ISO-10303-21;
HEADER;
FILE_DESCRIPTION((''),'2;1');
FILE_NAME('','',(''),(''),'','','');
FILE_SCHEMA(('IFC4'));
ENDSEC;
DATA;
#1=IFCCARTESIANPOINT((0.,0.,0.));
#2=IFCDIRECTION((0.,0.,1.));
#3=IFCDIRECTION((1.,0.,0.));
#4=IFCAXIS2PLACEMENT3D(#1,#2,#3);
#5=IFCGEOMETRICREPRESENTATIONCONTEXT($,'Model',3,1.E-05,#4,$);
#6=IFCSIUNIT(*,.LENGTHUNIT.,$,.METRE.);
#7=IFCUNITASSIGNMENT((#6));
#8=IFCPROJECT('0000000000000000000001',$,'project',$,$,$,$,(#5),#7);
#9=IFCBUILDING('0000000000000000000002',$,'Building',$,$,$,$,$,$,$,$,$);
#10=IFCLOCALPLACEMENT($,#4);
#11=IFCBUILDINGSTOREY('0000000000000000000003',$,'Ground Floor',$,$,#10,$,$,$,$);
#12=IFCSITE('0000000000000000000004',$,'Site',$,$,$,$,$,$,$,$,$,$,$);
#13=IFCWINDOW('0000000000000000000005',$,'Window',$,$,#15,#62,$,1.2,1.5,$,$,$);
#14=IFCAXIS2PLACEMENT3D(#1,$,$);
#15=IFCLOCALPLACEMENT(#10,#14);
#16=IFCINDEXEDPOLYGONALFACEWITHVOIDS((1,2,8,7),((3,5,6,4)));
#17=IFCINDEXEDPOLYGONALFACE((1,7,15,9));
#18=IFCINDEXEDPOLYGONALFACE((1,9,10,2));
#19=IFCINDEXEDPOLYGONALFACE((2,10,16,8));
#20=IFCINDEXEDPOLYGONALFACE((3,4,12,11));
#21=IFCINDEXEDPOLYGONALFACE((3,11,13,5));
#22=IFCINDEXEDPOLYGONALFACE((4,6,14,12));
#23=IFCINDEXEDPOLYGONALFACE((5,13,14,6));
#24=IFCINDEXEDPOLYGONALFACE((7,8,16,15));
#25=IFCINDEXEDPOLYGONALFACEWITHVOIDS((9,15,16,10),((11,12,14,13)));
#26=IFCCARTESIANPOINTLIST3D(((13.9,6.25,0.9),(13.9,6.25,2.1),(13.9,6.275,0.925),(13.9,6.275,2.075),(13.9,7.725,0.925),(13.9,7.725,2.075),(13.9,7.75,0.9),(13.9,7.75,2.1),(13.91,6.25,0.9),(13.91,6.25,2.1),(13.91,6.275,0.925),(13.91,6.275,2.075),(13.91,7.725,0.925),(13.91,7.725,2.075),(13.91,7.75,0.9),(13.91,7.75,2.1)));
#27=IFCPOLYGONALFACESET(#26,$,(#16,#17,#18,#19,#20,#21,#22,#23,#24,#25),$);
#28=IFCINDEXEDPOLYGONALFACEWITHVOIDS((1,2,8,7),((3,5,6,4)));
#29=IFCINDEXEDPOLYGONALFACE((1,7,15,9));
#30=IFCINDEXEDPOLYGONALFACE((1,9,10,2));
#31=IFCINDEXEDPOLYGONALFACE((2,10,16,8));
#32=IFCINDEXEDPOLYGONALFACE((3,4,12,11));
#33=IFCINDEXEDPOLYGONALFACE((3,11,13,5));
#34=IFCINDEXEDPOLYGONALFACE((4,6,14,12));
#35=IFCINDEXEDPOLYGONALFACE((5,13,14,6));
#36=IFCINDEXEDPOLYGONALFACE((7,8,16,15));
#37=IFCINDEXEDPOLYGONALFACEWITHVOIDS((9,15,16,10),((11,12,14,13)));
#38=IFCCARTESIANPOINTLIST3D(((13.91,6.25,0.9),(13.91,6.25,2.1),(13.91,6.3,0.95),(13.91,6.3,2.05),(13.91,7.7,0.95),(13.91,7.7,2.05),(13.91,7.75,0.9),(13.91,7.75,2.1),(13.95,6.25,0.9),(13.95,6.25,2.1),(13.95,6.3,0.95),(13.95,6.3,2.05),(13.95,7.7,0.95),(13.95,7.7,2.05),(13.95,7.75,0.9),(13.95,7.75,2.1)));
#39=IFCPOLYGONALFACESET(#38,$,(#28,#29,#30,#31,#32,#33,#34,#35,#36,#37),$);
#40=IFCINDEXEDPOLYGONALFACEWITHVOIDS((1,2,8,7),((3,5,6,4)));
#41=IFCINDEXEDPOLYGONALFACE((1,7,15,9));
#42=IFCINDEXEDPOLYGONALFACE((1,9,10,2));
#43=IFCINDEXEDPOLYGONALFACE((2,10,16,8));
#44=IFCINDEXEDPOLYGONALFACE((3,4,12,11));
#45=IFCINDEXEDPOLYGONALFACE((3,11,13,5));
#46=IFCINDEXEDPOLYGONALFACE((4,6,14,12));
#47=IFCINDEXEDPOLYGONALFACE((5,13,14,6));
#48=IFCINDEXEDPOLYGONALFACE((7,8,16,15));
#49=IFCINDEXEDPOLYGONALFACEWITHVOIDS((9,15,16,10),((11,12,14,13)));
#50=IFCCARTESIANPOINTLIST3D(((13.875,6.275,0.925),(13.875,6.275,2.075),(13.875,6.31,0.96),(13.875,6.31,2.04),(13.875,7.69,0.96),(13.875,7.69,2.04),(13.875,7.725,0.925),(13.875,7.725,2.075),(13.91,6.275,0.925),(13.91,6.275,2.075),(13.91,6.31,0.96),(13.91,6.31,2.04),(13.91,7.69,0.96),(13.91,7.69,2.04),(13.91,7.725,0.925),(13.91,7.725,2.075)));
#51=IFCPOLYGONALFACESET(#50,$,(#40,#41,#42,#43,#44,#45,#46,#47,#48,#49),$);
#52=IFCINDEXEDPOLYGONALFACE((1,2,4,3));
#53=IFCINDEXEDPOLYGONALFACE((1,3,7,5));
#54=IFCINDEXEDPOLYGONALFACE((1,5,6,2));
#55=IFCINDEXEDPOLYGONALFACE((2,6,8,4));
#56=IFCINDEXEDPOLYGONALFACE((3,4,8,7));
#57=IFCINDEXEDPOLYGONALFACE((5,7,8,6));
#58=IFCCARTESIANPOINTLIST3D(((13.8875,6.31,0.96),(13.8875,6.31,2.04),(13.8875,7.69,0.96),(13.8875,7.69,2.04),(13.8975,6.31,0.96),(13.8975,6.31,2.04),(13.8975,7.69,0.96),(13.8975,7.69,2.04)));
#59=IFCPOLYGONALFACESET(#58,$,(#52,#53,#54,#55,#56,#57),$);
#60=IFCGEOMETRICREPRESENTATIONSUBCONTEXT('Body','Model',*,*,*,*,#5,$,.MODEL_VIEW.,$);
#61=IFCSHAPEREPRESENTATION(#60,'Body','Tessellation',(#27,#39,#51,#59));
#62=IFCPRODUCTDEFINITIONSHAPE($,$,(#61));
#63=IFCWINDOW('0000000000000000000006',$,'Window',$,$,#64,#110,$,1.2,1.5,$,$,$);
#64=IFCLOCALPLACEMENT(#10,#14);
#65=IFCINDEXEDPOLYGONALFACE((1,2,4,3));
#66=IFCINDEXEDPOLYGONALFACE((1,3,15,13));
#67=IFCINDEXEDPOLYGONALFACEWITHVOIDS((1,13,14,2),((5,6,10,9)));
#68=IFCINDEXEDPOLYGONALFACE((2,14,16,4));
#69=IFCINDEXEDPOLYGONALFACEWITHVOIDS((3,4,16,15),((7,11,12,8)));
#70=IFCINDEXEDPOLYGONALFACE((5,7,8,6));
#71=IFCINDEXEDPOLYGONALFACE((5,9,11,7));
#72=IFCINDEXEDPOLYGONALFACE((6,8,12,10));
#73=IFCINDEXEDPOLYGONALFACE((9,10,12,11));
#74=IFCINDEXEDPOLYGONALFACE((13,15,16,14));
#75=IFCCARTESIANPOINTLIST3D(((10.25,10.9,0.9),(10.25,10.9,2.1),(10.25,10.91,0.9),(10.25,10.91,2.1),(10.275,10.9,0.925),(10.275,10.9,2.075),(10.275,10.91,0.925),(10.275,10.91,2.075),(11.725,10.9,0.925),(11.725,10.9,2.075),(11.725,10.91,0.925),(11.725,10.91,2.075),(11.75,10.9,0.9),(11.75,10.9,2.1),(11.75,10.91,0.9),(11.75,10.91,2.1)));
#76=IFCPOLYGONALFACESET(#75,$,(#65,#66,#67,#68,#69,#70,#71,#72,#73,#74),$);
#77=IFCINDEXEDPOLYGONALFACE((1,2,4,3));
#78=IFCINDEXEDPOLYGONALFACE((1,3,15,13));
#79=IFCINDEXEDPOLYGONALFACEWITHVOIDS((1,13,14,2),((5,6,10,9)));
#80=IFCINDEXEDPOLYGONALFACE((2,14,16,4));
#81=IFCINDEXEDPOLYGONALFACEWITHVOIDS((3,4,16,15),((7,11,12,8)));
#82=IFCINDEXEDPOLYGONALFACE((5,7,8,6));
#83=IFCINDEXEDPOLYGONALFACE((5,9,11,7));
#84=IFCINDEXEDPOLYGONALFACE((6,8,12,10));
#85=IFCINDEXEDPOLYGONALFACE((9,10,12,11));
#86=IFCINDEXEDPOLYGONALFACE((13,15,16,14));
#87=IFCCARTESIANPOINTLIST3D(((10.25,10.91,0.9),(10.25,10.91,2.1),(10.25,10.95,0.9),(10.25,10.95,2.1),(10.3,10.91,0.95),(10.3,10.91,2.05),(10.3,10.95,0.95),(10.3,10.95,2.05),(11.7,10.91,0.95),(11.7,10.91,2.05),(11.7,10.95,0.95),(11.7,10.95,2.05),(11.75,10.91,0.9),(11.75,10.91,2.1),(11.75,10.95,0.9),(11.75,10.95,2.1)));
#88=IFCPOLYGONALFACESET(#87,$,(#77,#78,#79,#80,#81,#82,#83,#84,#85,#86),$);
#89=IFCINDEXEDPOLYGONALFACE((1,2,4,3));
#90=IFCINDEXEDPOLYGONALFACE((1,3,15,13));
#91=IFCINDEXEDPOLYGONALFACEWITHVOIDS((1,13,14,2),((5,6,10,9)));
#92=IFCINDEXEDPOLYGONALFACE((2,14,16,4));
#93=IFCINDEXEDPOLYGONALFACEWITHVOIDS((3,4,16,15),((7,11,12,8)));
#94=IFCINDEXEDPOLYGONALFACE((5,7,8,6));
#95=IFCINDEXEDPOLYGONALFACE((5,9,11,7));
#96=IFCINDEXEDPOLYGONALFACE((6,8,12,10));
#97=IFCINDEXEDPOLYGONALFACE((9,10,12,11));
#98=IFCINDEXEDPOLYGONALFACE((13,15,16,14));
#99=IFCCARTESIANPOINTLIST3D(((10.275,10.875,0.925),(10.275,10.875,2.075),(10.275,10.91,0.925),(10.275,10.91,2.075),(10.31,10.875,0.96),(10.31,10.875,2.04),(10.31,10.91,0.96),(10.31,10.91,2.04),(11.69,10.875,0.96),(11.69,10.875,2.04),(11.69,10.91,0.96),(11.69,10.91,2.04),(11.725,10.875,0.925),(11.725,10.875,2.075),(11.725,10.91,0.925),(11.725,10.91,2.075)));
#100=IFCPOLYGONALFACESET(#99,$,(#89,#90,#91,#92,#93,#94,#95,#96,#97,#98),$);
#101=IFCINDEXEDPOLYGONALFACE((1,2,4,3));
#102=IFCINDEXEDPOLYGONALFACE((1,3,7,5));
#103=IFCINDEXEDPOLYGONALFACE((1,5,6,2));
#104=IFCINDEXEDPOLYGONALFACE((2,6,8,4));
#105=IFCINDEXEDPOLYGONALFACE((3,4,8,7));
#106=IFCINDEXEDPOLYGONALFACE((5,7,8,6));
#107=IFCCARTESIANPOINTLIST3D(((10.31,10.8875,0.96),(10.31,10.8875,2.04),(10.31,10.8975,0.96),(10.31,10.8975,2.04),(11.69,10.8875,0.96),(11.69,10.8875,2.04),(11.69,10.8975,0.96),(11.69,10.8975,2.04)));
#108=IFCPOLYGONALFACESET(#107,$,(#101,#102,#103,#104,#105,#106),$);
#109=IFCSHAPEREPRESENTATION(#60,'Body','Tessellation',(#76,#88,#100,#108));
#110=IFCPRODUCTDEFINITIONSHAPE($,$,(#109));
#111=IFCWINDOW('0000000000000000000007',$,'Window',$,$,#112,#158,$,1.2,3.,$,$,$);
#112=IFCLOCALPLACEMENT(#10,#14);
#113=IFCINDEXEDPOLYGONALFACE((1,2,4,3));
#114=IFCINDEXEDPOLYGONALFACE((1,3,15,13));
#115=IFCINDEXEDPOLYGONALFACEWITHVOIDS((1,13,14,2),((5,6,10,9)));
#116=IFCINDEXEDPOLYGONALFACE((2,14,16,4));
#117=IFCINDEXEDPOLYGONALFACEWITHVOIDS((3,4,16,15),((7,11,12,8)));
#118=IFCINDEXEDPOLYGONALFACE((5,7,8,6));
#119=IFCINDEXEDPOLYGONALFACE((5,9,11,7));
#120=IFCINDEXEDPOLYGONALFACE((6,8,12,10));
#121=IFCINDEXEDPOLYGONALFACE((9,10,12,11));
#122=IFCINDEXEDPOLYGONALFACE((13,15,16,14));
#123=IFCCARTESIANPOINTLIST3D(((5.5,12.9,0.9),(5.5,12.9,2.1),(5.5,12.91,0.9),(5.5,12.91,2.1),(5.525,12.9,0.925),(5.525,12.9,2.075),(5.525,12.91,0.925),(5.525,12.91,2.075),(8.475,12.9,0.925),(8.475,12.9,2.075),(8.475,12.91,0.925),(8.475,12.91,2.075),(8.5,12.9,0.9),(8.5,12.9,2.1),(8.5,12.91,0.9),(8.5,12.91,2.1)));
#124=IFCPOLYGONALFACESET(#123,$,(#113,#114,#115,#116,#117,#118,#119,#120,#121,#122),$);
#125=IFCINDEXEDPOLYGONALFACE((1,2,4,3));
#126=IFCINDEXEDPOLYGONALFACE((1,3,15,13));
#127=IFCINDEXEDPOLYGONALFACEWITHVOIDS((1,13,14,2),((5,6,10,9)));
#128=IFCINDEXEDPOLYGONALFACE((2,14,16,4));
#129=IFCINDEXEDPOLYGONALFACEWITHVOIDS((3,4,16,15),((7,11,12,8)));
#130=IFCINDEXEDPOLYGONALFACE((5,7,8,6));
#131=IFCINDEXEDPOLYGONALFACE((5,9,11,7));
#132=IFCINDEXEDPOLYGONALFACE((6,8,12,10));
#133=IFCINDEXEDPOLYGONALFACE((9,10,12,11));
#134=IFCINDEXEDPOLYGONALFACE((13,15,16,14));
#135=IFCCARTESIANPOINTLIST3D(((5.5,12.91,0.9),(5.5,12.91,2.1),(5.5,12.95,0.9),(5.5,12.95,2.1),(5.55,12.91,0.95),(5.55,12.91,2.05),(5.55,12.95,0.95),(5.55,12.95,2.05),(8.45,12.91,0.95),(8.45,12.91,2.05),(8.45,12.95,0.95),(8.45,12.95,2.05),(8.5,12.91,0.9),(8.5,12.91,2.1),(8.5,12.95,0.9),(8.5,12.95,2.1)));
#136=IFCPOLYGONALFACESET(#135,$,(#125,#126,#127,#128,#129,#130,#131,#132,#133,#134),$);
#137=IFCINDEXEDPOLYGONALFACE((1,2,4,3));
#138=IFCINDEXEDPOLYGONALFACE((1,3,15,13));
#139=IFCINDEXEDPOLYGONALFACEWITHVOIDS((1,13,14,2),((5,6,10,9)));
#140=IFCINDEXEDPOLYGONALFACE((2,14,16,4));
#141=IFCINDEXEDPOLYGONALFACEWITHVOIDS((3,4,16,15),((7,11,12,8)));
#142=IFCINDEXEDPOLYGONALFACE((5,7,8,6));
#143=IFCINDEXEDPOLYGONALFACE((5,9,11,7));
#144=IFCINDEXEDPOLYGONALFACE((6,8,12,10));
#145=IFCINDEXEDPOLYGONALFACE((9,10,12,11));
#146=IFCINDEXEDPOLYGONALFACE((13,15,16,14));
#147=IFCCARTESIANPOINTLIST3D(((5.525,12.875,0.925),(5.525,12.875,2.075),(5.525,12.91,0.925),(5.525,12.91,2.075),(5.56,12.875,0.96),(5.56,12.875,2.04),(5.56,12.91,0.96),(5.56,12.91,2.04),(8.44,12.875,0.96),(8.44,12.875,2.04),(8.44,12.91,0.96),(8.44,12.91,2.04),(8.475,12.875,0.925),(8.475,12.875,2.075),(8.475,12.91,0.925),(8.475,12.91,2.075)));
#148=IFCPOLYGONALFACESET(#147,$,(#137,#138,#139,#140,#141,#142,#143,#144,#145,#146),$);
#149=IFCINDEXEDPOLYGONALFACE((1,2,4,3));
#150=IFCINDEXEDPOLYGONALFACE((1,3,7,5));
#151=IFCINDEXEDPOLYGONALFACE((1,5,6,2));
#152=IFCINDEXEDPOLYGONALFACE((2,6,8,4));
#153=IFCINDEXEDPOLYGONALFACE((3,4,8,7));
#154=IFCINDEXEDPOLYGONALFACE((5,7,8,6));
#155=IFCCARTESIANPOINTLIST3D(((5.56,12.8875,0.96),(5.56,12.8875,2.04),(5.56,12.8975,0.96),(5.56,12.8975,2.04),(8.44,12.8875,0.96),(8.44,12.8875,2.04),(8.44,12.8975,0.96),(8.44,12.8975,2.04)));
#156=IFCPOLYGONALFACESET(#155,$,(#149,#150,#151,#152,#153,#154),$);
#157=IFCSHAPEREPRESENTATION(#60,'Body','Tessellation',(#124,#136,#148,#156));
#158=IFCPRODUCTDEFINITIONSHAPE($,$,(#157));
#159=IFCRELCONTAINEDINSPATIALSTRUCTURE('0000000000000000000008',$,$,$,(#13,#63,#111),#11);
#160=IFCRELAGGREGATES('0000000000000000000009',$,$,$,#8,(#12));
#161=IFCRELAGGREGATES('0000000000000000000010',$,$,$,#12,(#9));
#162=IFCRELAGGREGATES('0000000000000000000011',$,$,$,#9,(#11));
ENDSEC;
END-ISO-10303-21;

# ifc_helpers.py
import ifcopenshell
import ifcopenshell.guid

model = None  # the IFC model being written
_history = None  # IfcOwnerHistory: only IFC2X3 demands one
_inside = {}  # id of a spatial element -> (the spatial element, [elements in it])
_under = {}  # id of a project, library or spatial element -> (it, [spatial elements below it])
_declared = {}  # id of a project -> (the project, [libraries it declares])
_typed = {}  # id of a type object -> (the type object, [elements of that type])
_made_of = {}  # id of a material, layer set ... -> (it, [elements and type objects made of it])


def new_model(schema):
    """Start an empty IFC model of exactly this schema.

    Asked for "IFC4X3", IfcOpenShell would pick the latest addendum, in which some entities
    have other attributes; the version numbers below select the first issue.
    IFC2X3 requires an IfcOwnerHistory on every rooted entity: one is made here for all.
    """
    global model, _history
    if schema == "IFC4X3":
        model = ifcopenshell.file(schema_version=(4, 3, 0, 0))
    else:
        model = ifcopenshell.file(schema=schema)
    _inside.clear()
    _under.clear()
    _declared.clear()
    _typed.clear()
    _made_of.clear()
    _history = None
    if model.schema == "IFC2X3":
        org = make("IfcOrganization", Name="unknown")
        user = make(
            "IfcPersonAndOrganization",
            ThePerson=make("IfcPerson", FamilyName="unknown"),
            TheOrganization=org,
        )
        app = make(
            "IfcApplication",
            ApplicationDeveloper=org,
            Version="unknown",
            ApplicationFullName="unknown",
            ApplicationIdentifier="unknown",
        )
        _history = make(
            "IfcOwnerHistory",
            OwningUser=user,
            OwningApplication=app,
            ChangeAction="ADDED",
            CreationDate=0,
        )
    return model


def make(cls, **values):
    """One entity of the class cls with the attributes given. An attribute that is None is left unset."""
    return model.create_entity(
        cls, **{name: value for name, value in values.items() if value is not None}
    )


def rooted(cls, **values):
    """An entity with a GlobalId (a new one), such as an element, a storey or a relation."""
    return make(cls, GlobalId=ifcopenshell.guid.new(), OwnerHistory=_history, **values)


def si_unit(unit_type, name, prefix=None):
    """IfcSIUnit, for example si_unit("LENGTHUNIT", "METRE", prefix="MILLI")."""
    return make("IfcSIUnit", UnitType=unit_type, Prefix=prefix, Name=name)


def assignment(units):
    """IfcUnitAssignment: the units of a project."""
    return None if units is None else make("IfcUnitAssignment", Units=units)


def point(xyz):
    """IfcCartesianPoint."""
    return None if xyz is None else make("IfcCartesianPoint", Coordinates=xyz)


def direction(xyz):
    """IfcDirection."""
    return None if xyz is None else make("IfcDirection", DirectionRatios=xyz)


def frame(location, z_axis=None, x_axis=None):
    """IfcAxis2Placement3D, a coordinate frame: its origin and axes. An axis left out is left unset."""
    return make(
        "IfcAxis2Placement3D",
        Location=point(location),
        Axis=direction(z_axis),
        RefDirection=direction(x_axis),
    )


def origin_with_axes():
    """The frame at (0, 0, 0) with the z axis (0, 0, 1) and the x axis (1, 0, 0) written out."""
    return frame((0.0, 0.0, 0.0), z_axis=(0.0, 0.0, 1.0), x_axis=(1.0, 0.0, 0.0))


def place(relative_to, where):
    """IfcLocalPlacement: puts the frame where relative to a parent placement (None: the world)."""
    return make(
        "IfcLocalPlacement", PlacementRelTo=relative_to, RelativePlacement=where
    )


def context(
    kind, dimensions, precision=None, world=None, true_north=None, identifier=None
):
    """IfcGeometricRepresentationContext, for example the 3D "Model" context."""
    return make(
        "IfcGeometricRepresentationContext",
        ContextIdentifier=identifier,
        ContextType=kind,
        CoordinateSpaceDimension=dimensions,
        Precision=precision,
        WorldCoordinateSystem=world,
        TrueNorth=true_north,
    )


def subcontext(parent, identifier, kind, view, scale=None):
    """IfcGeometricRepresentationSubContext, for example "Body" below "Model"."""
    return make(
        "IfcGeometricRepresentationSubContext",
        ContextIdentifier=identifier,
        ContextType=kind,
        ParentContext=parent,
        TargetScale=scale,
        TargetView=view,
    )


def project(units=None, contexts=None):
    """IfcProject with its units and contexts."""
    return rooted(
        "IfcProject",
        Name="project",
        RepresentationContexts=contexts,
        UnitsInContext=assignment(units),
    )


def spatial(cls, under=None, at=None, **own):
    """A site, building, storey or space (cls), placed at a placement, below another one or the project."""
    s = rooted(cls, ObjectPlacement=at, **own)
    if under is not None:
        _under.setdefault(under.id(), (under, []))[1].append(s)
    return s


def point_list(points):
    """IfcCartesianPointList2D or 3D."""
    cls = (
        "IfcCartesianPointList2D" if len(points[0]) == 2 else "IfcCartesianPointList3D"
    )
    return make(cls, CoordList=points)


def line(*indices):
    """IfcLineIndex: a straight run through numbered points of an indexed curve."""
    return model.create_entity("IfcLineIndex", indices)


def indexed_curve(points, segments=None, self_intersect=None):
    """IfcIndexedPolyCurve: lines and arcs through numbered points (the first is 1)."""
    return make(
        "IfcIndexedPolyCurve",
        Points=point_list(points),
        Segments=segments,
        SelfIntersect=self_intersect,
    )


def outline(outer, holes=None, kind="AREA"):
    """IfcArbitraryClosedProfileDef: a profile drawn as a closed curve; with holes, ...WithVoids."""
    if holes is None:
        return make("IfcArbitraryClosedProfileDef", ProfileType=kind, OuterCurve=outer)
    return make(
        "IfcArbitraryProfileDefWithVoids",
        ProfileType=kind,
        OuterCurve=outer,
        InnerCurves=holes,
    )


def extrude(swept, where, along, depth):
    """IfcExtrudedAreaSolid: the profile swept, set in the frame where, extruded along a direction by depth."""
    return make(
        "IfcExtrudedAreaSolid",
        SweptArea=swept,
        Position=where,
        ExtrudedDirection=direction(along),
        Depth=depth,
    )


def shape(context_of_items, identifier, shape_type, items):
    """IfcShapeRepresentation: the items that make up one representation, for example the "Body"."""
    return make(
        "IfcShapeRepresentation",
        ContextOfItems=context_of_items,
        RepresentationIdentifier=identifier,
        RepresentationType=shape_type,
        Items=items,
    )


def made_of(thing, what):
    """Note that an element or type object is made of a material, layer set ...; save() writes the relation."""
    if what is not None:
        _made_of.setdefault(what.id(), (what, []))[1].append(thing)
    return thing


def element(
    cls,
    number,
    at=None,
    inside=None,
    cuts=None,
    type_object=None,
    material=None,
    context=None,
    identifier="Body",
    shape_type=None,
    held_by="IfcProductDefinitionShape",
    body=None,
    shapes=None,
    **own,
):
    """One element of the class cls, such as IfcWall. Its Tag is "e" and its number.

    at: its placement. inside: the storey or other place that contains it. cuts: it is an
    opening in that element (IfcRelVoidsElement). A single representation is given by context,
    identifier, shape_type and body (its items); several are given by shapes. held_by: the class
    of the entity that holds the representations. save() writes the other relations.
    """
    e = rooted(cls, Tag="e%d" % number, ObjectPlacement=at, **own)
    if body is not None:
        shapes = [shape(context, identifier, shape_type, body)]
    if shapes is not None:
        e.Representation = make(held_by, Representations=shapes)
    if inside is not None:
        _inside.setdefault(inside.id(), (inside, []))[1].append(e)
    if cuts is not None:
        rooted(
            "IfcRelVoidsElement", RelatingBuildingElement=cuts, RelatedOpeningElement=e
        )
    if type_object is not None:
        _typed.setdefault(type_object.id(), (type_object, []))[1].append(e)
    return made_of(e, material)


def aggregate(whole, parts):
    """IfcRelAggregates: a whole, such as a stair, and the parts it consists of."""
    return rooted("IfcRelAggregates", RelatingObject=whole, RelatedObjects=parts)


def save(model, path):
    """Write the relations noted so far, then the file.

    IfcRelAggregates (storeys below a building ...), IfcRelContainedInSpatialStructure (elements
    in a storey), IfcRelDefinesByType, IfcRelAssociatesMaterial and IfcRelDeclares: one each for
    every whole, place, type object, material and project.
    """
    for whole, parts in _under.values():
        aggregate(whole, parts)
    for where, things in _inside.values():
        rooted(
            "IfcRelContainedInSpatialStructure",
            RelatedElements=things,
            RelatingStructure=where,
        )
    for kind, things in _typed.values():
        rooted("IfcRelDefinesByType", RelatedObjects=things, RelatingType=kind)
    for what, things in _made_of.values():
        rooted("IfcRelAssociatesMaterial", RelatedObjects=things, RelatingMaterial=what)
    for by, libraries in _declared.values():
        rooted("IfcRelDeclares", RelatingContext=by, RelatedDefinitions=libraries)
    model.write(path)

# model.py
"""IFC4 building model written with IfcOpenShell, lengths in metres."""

from ifc_helpers import new_model, si_unit, frame, origin_with_axes, place, context, subcontext, project, spatial, line, indexed_curve, outline, extrude, element, save


model = new_model("IFC4")

# Units and contexts
model_context = context("Model", 3, precision=1e-05, world=origin_with_axes())
body_context = subcontext(model_context, "Body", "Model", "MODEL_VIEW")
ifc_project = project(units=[si_unit("LENGTHUNIT", "METRE")], contexts=[model_context])

# Site, building, storey
site = spatial("IfcSite", under=ifc_project, Name="Site")
building = spatial("IfcBuilding", under=site, Name="Building")
storey_placement = place(None, origin_with_axes())
storey = spatial("IfcBuildingStorey", under=building, at=storey_placement, Name="Ground Floor")

# Windows
for number, where, z_axis, x_axis, name in (
    (1, (14.0, 6.25, 0.9), (0.0, 0.0, 1.0), (0.0, 1.0, 0.0), "Window"),
    (2, (11.75, 11.0, 0.9), (0.0, 0.0, 1.0), (-1.0, 0.0, 0.0), "Window"),
):
    element("IfcWindow", number, at=place(storey_placement, frame(where, z_axis=z_axis, x_axis=x_axis)), inside=storey, Name=name, OverallHeight=1.2, OverallWidth=1.5, context=body_context, shape_type="SweptSolid", body=[
        extrude(outline(indexed_curve([(0.0, 0.0), (1.5, 0.0), (1.5, 1.2), (0.0, 1.2)], segments=[line(1, 2, 3, 4, 1)]), holes=[indexed_curve([(0.025, 0.025), (1.475, 0.025), (1.475, 1.175), (0.025, 1.175)], segments=[line(1, 2, 3, 4, 1)])]), frame((0.0, 0.09, 0.0), z_axis=(0.0, -1.0, 0.0), x_axis=(1.0, 0.0, 0.0)), (0.0, 0.0, -1.0), 0.01),
        extrude(outline(indexed_curve([(0.0, 0.0), (1.5, 0.0), (1.5, 1.2), (0.0, 1.2)], segments=[line(1, 2, 3, 4, 1)]), holes=[indexed_curve([(0.05, 0.05), (1.45, 0.05), (1.45, 1.15), (0.05, 1.15)], segments=[line(1, 2, 3, 4, 1)])]), frame((0.0, 0.05, 0.0), z_axis=(0.0, -1.0, 0.0), x_axis=(1.0, 0.0, 0.0)), (0.0, 0.0, -1.0), 0.04),
        extrude(outline(indexed_curve([(0.0, 0.0), (1.45, 0.0), (1.45, 1.15), (0.0, 1.15)], segments=[line(1, 2, 3, 4, 1)]), holes=[indexed_curve([(0.035, 0.035), (1.415, 0.035), (1.415, 1.115), (0.035, 1.115)], segments=[line(1, 2, 3, 4, 1)])]), frame((0.025, 0.09, 0.025), z_axis=(0.0, -1.0, 0.0), x_axis=(1.0, 0.0, 0.0)), (0.0, 0.0, -1.0), 0.035),
        extrude(outline(indexed_curve([(0.035, 0.035), (1.415, 0.035), (1.415, 1.115), (0.035, 1.115)], segments=[line(1, 2, 3, 4, 1)])), frame((0.025, 0.1025, 0.025), z_axis=(0.0, -1.0, 0.0), x_axis=(1.0, 0.0, 0.0)), (0.0, 0.0, -1.0), 0.01),
    ])
window_placement = place(storey_placement, frame((8.5, 13.0, 0.9), z_axis=(0.0, 0.0, 1.0), x_axis=(-1.0, 0.0, 0.0)))
element("IfcWindow", 3, at=window_placement, inside=storey, Name="Window", OverallHeight=1.2, OverallWidth=3.0, context=body_context, shape_type="SweptSolid", body=[
    extrude(outline(indexed_curve([(0.0, 0.0), (3.0, 0.0), (3.0, 1.2), (0.0, 1.2)], segments=[line(1, 2, 3, 4, 1)]), holes=[indexed_curve([(0.025, 0.025), (2.975, 0.025), (2.975, 1.175), (0.025, 1.175)], segments=[line(1, 2, 3, 4, 1)])]), frame((0.0, 0.09, 0.0), z_axis=(0.0, -1.0, 0.0), x_axis=(1.0, 0.0, 0.0)), (0.0, 0.0, -1.0), 0.01),
    extrude(outline(indexed_curve([(0.0, 0.0), (3.0, 0.0), (3.0, 1.2), (0.0, 1.2)], segments=[line(1, 2, 3, 4, 1)]), holes=[indexed_curve([(0.05, 0.05), (2.95, 0.05), (2.95, 1.15), (0.05, 1.15)], segments=[line(1, 2, 3, 4, 1)])]), frame((0.0, 0.05, 0.0), z_axis=(0.0, -1.0, 0.0), x_axis=(1.0, 0.0, 0.0)), (0.0, 0.0, -1.0), 0.04),
    extrude(outline(indexed_curve([(0.0, 0.0), (2.95, 0.0), (2.95, 1.15), (0.0, 1.15)], segments=[line(1, 2, 3, 4, 1)]), holes=[indexed_curve([(0.035, 0.035), (2.915, 0.035), (2.915, 1.115), (0.035, 1.115)], segments=[line(1, 2, 3, 4, 1)])]), frame((0.025, 0.09, 0.025), z_axis=(0.0, -1.0, 0.0), x_axis=(1.0, 0.0, 0.0)), (0.0, 0.0, -1.0), 0.035),
    extrude(outline(indexed_curve([(0.035, 0.035), (2.915, 0.035), (2.915, 1.115), (0.035, 1.115)], segments=[line(1, 2, 3, 4, 1)])), frame((0.025, 0.1025, 0.025), z_axis=(0.0, -1.0, 0.0), x_axis=(1.0, 0.0, 0.0)), (0.0, 0.0, -1.0), 0.01),
])

save(model, "model.ifc")
